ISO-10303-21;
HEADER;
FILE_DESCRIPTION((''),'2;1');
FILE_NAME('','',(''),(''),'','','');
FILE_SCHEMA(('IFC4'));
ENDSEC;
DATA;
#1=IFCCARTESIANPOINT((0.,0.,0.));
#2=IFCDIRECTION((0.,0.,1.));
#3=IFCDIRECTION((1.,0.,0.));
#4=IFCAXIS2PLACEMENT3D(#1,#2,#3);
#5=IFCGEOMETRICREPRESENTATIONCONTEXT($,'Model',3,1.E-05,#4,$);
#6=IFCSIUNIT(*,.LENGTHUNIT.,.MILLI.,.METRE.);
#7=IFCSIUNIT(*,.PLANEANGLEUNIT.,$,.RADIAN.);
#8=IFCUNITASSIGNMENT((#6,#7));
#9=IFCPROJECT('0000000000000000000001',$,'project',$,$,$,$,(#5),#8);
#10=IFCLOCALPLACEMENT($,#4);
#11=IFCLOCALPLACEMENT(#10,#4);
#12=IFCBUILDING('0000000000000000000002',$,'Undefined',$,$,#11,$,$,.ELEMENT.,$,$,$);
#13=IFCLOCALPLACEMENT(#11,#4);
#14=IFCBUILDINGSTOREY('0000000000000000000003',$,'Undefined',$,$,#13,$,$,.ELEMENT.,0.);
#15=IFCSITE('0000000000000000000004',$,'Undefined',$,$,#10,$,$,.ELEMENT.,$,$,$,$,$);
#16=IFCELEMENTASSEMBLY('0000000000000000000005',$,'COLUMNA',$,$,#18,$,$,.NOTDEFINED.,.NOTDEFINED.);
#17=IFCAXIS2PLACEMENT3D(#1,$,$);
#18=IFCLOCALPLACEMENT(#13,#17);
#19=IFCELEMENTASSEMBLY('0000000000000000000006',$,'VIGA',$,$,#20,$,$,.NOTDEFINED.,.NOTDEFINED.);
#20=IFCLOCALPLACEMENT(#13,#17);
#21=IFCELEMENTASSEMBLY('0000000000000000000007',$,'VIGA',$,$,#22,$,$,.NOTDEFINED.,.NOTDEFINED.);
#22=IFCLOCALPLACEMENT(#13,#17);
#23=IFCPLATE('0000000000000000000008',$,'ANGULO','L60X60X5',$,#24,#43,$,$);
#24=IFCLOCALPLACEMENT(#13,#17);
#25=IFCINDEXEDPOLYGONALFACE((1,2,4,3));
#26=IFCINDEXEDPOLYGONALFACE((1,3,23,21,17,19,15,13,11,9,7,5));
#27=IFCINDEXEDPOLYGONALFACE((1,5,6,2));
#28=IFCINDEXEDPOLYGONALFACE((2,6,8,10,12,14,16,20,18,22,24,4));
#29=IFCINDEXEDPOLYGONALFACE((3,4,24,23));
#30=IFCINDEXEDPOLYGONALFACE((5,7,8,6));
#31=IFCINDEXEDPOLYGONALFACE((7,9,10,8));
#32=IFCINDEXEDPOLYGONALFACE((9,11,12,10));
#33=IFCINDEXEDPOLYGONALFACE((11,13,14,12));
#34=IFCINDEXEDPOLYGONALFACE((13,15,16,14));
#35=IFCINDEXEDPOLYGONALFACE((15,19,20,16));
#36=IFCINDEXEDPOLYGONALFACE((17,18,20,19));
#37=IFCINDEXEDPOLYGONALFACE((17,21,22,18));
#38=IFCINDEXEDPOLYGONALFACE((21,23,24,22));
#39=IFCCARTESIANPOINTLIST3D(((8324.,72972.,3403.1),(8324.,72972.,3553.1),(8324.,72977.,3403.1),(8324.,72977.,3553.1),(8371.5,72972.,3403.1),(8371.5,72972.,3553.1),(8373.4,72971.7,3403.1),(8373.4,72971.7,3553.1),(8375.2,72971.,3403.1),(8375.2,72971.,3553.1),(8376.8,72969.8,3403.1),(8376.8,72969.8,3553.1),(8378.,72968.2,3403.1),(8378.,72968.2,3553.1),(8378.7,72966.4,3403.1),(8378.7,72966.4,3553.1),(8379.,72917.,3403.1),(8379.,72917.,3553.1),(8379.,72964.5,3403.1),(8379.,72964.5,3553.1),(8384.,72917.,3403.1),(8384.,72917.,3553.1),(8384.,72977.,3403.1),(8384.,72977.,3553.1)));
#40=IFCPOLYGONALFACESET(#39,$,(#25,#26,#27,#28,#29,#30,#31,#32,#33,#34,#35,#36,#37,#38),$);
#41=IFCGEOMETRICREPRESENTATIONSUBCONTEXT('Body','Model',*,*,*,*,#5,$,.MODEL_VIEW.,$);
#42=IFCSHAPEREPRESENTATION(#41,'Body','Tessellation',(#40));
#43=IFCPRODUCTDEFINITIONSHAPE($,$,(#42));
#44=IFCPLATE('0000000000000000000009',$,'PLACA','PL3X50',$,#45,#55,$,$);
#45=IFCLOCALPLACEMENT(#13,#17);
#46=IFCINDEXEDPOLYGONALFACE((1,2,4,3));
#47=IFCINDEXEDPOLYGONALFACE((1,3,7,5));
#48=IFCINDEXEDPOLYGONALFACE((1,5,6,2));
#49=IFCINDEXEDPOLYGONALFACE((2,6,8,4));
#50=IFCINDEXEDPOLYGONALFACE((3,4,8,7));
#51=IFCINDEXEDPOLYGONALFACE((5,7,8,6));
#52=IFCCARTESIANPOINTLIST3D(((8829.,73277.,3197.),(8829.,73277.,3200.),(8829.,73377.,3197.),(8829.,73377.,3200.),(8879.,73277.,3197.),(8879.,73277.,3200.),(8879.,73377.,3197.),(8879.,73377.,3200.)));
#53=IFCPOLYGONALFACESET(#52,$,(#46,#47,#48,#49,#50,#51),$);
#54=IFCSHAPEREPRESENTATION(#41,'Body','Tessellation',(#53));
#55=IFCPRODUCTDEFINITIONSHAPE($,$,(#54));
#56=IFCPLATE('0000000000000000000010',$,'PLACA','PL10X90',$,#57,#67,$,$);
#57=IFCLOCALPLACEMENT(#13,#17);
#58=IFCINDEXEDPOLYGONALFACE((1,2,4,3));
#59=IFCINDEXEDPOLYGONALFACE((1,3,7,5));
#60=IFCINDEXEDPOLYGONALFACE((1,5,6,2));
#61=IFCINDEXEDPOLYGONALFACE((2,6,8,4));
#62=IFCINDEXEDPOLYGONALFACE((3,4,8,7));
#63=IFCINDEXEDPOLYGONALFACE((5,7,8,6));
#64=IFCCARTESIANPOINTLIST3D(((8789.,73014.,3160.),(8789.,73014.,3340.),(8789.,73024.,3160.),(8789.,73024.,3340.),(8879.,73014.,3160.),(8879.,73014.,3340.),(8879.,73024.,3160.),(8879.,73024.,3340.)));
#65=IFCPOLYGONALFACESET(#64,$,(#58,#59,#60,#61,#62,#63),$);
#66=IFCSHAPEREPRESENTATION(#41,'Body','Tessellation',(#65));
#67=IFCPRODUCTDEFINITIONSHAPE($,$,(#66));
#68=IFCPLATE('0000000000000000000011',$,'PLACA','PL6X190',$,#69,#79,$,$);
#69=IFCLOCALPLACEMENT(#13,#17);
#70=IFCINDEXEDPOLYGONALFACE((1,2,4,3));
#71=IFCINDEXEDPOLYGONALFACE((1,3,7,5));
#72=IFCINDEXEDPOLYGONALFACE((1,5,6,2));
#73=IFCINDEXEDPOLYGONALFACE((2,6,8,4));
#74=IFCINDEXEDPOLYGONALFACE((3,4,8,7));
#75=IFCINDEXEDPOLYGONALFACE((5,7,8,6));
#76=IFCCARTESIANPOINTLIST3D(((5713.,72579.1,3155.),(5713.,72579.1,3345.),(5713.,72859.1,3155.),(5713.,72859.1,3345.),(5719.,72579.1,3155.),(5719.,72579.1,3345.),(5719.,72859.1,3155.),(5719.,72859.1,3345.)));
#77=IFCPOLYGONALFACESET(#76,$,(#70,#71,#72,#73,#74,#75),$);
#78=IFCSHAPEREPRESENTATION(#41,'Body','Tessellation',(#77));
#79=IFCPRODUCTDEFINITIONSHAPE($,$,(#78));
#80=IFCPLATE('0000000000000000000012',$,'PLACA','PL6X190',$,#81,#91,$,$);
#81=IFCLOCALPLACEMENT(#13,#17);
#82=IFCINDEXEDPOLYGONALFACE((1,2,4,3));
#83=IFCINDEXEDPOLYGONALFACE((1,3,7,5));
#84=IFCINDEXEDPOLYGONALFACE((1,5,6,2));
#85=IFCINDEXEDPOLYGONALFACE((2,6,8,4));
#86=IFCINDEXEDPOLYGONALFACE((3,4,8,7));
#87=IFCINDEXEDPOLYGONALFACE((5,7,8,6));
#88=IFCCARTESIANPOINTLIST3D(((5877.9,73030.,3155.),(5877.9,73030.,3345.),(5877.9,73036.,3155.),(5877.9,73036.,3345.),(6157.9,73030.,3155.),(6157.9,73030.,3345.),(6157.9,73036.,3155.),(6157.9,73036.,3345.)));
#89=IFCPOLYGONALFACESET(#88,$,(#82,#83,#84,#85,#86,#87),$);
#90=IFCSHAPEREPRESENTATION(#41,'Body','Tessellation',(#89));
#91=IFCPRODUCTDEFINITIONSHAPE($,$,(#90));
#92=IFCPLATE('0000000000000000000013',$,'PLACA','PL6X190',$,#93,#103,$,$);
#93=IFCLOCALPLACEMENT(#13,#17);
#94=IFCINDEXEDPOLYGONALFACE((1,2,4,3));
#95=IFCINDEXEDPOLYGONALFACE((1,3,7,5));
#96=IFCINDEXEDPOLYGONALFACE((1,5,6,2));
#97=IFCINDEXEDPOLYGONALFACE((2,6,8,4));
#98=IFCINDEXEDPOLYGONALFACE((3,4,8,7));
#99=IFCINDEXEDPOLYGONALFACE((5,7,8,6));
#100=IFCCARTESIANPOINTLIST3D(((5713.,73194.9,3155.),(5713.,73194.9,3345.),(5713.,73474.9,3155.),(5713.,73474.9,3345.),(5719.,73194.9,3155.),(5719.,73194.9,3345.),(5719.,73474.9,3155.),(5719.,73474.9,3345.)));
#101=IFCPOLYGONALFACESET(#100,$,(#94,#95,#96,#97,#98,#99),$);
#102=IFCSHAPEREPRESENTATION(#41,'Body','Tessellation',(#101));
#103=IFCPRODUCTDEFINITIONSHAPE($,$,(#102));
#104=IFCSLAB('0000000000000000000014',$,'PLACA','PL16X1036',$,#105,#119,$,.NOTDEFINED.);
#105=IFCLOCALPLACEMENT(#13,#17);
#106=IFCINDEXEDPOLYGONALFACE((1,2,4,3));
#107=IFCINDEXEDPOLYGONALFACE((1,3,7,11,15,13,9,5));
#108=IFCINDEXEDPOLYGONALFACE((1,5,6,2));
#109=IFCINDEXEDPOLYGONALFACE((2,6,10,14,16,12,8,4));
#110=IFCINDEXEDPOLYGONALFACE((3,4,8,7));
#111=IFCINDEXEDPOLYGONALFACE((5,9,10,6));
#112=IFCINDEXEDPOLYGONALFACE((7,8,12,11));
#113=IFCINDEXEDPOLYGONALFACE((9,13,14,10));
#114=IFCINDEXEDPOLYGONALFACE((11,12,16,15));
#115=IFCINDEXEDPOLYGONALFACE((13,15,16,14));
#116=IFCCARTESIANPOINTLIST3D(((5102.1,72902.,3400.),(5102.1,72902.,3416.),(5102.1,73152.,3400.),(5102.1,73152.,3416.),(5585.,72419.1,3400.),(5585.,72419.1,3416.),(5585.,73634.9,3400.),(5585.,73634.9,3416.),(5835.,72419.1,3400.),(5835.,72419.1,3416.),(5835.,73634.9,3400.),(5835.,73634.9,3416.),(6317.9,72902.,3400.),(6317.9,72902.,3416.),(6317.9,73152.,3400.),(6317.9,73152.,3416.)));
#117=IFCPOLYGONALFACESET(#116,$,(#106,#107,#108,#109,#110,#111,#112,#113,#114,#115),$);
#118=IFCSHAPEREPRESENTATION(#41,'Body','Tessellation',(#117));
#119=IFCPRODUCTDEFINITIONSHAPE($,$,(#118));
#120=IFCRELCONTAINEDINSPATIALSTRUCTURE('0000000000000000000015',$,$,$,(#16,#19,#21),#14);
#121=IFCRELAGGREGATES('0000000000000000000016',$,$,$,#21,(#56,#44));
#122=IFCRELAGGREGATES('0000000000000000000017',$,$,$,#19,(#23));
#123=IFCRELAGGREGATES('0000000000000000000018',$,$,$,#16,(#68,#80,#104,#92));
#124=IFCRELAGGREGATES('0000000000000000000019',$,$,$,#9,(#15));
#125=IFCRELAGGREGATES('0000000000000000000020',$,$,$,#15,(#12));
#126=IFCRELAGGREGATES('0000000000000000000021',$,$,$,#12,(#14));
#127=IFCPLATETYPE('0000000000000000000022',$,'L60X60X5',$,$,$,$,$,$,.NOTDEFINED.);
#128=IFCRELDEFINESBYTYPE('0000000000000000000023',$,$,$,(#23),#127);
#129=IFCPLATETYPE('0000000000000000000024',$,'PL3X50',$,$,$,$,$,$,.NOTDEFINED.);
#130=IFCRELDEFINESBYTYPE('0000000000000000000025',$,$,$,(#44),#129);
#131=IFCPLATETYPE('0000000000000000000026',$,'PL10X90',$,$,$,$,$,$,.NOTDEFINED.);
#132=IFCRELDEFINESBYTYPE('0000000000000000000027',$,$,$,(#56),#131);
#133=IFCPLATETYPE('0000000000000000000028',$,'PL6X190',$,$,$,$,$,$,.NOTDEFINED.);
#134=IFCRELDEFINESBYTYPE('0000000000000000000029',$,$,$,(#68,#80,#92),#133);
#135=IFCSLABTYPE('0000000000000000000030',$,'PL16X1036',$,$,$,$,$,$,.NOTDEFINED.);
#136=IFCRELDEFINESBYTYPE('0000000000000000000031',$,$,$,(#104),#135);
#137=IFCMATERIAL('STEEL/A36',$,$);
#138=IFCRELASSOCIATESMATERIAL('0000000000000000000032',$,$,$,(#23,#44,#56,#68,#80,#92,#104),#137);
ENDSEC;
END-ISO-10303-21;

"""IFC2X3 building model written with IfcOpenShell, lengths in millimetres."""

from ifc_helpers import new_model, si_unit, frame, origin_with_axes, origin_2d_with_axis, place, context, subcontext, project, spatial, polyline, l_section, outline, extrude, material, type_object, element, aggregate, save


model = new_model("IFC2X3")

# Units and contexts
model_context = context("Model", 3, precision=1e-05, world=origin_with_axes())
body_context = subcontext(model_context, "Body", "Model", "MODEL_VIEW")
ifc_project = project(units=[si_unit("LENGTHUNIT", "METRE", prefix="MILLI"), si_unit("PLANEANGLEUNIT", "RADIAN")], contexts=[model_context])

# Site, building, storey
site_placement = place(None, origin_with_axes())
site = spatial("IfcSite", under=ifc_project, at=site_placement, Name="Undefined", CompositionType="ELEMENT")
building_placement = place(site_placement, origin_with_axes())
building = spatial("IfcBuilding", under=site, at=building_placement, Name="Undefined", CompositionType="ELEMENT")
storey_placement = place(building_placement, origin_with_axes())
storey = spatial("IfcBuildingStorey", under=building, at=storey_placement, Name="Undefined", CompositionType="ELEMENT", Elevation=0.0)

# Element assembly
assembly_1_placement = place(storey_placement, origin_with_axes())
assembly_1 = element("IfcElementAssembly", 1, at=assembly_1_placement, inside=storey, Name="COLUMNA", AssemblyPlace="NOTDEFINED", PredefinedType="NOTDEFINED")
ifc_material_1 = material(Name="STEEL/A36")

# Element assembly
assembly_2_placement = place(storey_placement, origin_with_axes())
assembly_2 = element("IfcElementAssembly", 2, at=assembly_2_placement, inside=storey, Name="VIGA", AssemblyPlace="NOTDEFINED", PredefinedType="NOTDEFINED")

# Element assembly
assembly_3_placement = place(storey_placement, origin_with_axes())
assembly_3 = element("IfcElementAssembly", 3, at=assembly_3_placement, inside=storey, Name="VIGA", AssemblyPlace="NOTDEFINED", PredefinedType="NOTDEFINED")
plate_type_1 = type_object("IfcPlateType", Name="L60X60X5", PredefinedType="NOTDEFINED")

# Plates
plate_1_placement = place(assembly_2_placement, frame((8354.0, 72947.0, 3403.1), z_axis=(-1.0, 0.0, 0.0), x_axis=(0.0, 0.0, 1.0)))
plate_1 = element("IfcPlate", 4, at=plate_1_placement, type_object=plate_type_1, material=ifc_material_1, Name="ANGULO", Description="L60X60X5", context=body_context, shape_type="SweptSolid", body=[
    extrude(l_section(Depth=60.0, Width=60.0, Thickness=5.0, FilletRadius=7.5, at=origin_2d_with_axis()), frame((150.0, 0.0, 0.0), z_axis=(-1.0, 0.0, 0.0), x_axis=(0.0, -1.0, 0.0)), (0.0, 0.0, 1.0), 150.0),
])
plate_type_2 = type_object("IfcPlateType", Name="PL3X50", PredefinedType="NOTDEFINED")
plate_2_placement = place(assembly_3_placement, frame((8829.0, 73277.0, 3198.5), z_axis=(0.0, 0.0, 1.0), x_axis=(1.0, 0.0, 0.0)))
plate_2 = element("IfcPlate", 5, at=plate_2_placement, type_object=plate_type_2, material=ifc_material_1, Name="PLACA", Description="PL3X50", context=body_context, shape_type="SweptSolid", body=[
    extrude(outline(polyline([(0.0, 0.0), (50.0, 0.0), (50.0, 100.0), (0.0, 100.0), (0.0, 0.0)])), frame((0.0, 0.0, -1.5), z_axis=(0.0, 0.0, 1.0), x_axis=(1.0, 0.0, 0.0)), (0.0, 0.0, 1.0), 3.0),
])
plate_type_3 = type_object("IfcPlateType", Name="PL10X90", PredefinedType="NOTDEFINED")
plate_3_placement = place(assembly_3_placement, frame((8879.0, 73019.0, 3340.0), z_axis=(0.0, 1.0, 0.0), x_axis=(0.0, 0.0, -1.0)))
plate_3 = element("IfcPlate", 6, at=plate_3_placement, type_object=plate_type_3, material=ifc_material_1, Name="PLACA", Description="PL10X90", context=body_context, shape_type="SweptSolid", body=[
    extrude(outline(polyline([(0.0, 0.0), (180.0, 0.0), (180.0, 90.0), (0.0, 90.0), (0.0, 0.0)])), frame((0.0, 0.0, -5.0), z_axis=(0.0, 0.0, 1.0), x_axis=(1.0, 0.0, 0.0)), (0.0, 0.0, 1.0), 10.0),
])
aggregate(assembly_3, [plate_3, plate_2])
plate_type_4 = type_object("IfcPlateType", Name="PL6X190", PredefinedType="NOTDEFINED")
plate_4_placement = place(assembly_1_placement, frame((5716.0, 72579.1, 3250.0), z_axis=(1.0, 0.0, 0.0), x_axis=(0.0, 1.0, 0.0)))
plate_4 = element("IfcPlate", 7, at=plate_4_placement, type_object=plate_type_4, material=ifc_material_1, Name="PLACA", Description="PL6X190", context=body_context, shape_type="SweptSolid", body=[
    extrude(outline(polyline([(0.0, -95.0), (0.0, 95.0), (280.0, 95.0), (280.0, -95.0), (0.0, -95.0)])), frame((0.0, 0.0, -3.0), z_axis=(0.0, 0.0, 1.0), x_axis=(1.0, 0.0, 0.0)), (0.0, 0.0, 1.0), 6.0),
])
plate_5_placement = place(assembly_1_placement, frame((6157.9, 73033.0, 3250.0), z_axis=(0.0, 1.0, 0.0), x_axis=(-1.0, 0.0, 0.0)))
plate_5 = element("IfcPlate", 8, at=plate_5_placement, type_object=plate_type_4, material=ifc_material_1, Name="PLACA", Description="PL6X190", context=body_context, shape_type="SweptSolid", body=[
    extrude(outline(polyline([(0.0, -95.0), (0.0, 95.0), (280.0, 95.0), (280.0, -95.0), (0.0, -95.0)])), frame((0.0, 0.0, -3.0), z_axis=(0.0, 0.0, 1.0), x_axis=(1.0, 0.0, 0.0)), (0.0, 0.0, 1.0), 6.0),
])
plate_6_placement = place(assembly_1_placement, frame((5716.0, 73474.9, 3250.0), z_axis=(-1.0, 0.0, 0.0), x_axis=(0.0, -1.0, 0.0)))
plate_6 = element("IfcPlate", 9, at=plate_6_placement, type_object=plate_type_4, material=ifc_material_1, Name="PLACA", Description="PL6X190", context=body_context, shape_type="SweptSolid", body=[
    extrude(outline(polyline([(0.0, -95.0), (0.0, 95.0), (280.0, 95.0), (280.0, -95.0), (0.0, -95.0)])), frame((0.0, 0.0, -3.0), z_axis=(0.0, 0.0, 1.0), x_axis=(1.0, 0.0, 0.0)), (0.0, 0.0, 1.0), 6.0),
])

# Slab
slab_type = type_object("IfcSlabType", Name="PL16X1036", PredefinedType="NOTDEFINED")
slab_placement = place(assembly_1_placement, frame((5835.0, 72419.1, 3408.0), z_axis=(0.0, 0.0, 1.0), x_axis=(0.707107, 0.707107, 0.0)))
slab = element("IfcSlab", 10, at=slab_placement, type_object=slab_type, material=ifc_material_1, Name="PLACA", Description="PL16X1036", PredefinedType="NOTDEFINED", context=body_context, shape_type="SweptSolid", body=[
    extrude(outline(polyline([(0.0, 0.0), (682.9, 0.0), (859.7, 176.8), (859.7, 859.7), (682.9, 1036.5), (0.0, 1036.5), (-176.8, 859.7), (-176.8, 176.8), (0.0, 0.0)])), frame((0.0, 0.0, -8.0), z_axis=(0.0, 0.0, 1.0), x_axis=(1.0, 0.0, 0.0)), (0.0, 0.0, 1.0), 16.0),
])

aggregate(assembly_2, [plate_1])
aggregate(assembly_1, [plate_4, plate_5, slab, plate_6])

save(model, "model.ifc")
